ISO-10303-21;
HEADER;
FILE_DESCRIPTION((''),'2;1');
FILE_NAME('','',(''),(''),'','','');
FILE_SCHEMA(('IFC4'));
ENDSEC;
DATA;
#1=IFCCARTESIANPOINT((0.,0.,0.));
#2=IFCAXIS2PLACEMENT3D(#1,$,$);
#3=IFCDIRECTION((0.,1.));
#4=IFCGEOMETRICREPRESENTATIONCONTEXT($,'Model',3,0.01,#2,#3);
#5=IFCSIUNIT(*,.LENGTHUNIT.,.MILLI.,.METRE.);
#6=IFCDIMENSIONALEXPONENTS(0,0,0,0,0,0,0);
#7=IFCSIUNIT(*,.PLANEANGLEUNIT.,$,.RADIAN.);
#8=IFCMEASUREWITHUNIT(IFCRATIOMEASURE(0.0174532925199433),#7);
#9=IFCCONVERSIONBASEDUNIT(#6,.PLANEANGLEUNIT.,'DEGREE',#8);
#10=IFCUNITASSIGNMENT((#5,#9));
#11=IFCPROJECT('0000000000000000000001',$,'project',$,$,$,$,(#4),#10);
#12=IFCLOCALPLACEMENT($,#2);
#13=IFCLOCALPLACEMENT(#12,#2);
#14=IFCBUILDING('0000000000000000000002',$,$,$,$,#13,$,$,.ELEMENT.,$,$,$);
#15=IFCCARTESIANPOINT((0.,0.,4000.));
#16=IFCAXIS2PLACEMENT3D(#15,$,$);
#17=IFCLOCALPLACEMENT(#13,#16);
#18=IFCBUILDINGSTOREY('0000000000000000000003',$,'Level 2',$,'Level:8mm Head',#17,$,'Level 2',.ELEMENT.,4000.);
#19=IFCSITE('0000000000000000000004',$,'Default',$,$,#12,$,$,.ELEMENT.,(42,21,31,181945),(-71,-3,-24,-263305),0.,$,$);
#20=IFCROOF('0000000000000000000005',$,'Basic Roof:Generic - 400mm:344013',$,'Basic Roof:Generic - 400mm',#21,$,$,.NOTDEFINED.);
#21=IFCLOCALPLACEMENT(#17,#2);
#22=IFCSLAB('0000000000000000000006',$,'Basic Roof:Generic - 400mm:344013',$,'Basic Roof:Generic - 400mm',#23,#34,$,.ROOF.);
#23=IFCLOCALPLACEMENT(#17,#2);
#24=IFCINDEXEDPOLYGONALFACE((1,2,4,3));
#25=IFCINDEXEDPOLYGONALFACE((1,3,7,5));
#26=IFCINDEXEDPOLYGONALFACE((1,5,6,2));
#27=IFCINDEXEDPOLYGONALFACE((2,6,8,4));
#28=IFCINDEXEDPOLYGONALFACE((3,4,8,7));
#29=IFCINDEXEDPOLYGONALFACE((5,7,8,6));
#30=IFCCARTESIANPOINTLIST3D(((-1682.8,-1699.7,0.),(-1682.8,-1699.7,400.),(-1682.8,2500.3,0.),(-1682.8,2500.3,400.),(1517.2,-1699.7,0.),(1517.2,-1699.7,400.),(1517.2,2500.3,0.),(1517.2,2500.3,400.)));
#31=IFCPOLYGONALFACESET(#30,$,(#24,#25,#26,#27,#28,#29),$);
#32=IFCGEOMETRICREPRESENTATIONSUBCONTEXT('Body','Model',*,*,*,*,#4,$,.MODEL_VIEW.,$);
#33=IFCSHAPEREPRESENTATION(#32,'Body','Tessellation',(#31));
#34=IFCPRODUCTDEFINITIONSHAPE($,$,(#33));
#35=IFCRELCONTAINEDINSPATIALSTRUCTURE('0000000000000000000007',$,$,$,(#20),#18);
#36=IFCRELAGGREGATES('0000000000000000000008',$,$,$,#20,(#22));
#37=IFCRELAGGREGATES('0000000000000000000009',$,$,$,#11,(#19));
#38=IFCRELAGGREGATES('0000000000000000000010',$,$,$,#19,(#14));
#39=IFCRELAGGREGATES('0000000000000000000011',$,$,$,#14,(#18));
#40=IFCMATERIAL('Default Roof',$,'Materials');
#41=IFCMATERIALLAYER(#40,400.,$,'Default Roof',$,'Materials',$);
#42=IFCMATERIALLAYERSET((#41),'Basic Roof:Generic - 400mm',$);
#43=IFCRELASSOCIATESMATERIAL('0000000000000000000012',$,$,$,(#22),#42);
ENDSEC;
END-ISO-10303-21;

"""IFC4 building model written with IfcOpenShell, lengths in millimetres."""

from ifc_helpers import new_model, entity, si_unit, converted_unit, direction, frame, frame_2d, origin, place, context, subcontext, project, spatial, rectangle, extrude, material, layer, layer_set, element, aggregate, save


model = new_model("IFC4")

# Units and contexts
model_context = context("Model", 3, precision=0.01, world=origin(), true_north=direction((0.0, 1.0)))
body_context = subcontext(model_context, "Body", "Model", "MODEL_VIEW")
ifc_project = project(units=[si_unit("LENGTHUNIT", "METRE", prefix="MILLI"), converted_unit("PLANEANGLEUNIT", "DEGREE", entity("IfcRatioMeasure", 0.0174532925199433), si_unit("PLANEANGLEUNIT", "RADIAN"), dimensions=[0, 0, 0, 0, 0, 0, 0])], contexts=[model_context])

# Site, building, storey
site_placement = place(None, origin())
site = spatial("IfcSite", under=ifc_project, at=site_placement, Name="Default", CompositionType="ELEMENT", RefLatitude=(42, 21, 31, 181945), RefLongitude=(-71, -3, -24, -263305), RefElevation=0.0)
building_placement = place(site_placement, origin())
building = spatial("IfcBuilding", under=site, at=building_placement, CompositionType="ELEMENT")
storey_placement = place(building_placement, frame((0.0, 0.0, 4000.0)))
storey = spatial("IfcBuildingStorey", under=building, at=storey_placement, Name="Level 2", ObjectType="Level:8mm Head", LongName="Level 2", CompositionType="ELEMENT", Elevation=4000.0)

# Roof, slab
roof_placement = place(storey_placement, frame((-1682.8, -1699.7, 0.0)))
roof = element("IfcRoof", 1, at=roof_placement, inside=storey, Name="Basic Roof:Generic - 400mm:344013", ObjectType="Basic Roof:Generic - 400mm", PredefinedType="NOTDEFINED")
ifc_material = material(Name="Default Roof", Category="Materials")
ifc_layer = layer(ifc_material, 400.0, Name="Default Roof", Category="Materials")
ifc_layer_set = layer_set([ifc_layer], Name="Basic Roof:Generic - 400mm")
slab_placement = place(roof_placement, origin())
slab = element("IfcSlab", 2, at=slab_placement, material=ifc_layer_set, Name="Basic Roof:Generic - 400mm:344013", ObjectType="Basic Roof:Generic - 400mm", PredefinedType="ROOF", context=body_context, shape_type="SweptSolid", body=[
    extrude(rectangle(XDim=3200.0, YDim=4200.0, at=frame_2d((0.0, 0.0), x_axis=(1.0, 0.0))), frame((1600.0, 2100.0, 0.0)), (0.0, 0.0, 1.0), 400.0),
])
aggregate(roof, [slab])

save(model, "model.ifc")
